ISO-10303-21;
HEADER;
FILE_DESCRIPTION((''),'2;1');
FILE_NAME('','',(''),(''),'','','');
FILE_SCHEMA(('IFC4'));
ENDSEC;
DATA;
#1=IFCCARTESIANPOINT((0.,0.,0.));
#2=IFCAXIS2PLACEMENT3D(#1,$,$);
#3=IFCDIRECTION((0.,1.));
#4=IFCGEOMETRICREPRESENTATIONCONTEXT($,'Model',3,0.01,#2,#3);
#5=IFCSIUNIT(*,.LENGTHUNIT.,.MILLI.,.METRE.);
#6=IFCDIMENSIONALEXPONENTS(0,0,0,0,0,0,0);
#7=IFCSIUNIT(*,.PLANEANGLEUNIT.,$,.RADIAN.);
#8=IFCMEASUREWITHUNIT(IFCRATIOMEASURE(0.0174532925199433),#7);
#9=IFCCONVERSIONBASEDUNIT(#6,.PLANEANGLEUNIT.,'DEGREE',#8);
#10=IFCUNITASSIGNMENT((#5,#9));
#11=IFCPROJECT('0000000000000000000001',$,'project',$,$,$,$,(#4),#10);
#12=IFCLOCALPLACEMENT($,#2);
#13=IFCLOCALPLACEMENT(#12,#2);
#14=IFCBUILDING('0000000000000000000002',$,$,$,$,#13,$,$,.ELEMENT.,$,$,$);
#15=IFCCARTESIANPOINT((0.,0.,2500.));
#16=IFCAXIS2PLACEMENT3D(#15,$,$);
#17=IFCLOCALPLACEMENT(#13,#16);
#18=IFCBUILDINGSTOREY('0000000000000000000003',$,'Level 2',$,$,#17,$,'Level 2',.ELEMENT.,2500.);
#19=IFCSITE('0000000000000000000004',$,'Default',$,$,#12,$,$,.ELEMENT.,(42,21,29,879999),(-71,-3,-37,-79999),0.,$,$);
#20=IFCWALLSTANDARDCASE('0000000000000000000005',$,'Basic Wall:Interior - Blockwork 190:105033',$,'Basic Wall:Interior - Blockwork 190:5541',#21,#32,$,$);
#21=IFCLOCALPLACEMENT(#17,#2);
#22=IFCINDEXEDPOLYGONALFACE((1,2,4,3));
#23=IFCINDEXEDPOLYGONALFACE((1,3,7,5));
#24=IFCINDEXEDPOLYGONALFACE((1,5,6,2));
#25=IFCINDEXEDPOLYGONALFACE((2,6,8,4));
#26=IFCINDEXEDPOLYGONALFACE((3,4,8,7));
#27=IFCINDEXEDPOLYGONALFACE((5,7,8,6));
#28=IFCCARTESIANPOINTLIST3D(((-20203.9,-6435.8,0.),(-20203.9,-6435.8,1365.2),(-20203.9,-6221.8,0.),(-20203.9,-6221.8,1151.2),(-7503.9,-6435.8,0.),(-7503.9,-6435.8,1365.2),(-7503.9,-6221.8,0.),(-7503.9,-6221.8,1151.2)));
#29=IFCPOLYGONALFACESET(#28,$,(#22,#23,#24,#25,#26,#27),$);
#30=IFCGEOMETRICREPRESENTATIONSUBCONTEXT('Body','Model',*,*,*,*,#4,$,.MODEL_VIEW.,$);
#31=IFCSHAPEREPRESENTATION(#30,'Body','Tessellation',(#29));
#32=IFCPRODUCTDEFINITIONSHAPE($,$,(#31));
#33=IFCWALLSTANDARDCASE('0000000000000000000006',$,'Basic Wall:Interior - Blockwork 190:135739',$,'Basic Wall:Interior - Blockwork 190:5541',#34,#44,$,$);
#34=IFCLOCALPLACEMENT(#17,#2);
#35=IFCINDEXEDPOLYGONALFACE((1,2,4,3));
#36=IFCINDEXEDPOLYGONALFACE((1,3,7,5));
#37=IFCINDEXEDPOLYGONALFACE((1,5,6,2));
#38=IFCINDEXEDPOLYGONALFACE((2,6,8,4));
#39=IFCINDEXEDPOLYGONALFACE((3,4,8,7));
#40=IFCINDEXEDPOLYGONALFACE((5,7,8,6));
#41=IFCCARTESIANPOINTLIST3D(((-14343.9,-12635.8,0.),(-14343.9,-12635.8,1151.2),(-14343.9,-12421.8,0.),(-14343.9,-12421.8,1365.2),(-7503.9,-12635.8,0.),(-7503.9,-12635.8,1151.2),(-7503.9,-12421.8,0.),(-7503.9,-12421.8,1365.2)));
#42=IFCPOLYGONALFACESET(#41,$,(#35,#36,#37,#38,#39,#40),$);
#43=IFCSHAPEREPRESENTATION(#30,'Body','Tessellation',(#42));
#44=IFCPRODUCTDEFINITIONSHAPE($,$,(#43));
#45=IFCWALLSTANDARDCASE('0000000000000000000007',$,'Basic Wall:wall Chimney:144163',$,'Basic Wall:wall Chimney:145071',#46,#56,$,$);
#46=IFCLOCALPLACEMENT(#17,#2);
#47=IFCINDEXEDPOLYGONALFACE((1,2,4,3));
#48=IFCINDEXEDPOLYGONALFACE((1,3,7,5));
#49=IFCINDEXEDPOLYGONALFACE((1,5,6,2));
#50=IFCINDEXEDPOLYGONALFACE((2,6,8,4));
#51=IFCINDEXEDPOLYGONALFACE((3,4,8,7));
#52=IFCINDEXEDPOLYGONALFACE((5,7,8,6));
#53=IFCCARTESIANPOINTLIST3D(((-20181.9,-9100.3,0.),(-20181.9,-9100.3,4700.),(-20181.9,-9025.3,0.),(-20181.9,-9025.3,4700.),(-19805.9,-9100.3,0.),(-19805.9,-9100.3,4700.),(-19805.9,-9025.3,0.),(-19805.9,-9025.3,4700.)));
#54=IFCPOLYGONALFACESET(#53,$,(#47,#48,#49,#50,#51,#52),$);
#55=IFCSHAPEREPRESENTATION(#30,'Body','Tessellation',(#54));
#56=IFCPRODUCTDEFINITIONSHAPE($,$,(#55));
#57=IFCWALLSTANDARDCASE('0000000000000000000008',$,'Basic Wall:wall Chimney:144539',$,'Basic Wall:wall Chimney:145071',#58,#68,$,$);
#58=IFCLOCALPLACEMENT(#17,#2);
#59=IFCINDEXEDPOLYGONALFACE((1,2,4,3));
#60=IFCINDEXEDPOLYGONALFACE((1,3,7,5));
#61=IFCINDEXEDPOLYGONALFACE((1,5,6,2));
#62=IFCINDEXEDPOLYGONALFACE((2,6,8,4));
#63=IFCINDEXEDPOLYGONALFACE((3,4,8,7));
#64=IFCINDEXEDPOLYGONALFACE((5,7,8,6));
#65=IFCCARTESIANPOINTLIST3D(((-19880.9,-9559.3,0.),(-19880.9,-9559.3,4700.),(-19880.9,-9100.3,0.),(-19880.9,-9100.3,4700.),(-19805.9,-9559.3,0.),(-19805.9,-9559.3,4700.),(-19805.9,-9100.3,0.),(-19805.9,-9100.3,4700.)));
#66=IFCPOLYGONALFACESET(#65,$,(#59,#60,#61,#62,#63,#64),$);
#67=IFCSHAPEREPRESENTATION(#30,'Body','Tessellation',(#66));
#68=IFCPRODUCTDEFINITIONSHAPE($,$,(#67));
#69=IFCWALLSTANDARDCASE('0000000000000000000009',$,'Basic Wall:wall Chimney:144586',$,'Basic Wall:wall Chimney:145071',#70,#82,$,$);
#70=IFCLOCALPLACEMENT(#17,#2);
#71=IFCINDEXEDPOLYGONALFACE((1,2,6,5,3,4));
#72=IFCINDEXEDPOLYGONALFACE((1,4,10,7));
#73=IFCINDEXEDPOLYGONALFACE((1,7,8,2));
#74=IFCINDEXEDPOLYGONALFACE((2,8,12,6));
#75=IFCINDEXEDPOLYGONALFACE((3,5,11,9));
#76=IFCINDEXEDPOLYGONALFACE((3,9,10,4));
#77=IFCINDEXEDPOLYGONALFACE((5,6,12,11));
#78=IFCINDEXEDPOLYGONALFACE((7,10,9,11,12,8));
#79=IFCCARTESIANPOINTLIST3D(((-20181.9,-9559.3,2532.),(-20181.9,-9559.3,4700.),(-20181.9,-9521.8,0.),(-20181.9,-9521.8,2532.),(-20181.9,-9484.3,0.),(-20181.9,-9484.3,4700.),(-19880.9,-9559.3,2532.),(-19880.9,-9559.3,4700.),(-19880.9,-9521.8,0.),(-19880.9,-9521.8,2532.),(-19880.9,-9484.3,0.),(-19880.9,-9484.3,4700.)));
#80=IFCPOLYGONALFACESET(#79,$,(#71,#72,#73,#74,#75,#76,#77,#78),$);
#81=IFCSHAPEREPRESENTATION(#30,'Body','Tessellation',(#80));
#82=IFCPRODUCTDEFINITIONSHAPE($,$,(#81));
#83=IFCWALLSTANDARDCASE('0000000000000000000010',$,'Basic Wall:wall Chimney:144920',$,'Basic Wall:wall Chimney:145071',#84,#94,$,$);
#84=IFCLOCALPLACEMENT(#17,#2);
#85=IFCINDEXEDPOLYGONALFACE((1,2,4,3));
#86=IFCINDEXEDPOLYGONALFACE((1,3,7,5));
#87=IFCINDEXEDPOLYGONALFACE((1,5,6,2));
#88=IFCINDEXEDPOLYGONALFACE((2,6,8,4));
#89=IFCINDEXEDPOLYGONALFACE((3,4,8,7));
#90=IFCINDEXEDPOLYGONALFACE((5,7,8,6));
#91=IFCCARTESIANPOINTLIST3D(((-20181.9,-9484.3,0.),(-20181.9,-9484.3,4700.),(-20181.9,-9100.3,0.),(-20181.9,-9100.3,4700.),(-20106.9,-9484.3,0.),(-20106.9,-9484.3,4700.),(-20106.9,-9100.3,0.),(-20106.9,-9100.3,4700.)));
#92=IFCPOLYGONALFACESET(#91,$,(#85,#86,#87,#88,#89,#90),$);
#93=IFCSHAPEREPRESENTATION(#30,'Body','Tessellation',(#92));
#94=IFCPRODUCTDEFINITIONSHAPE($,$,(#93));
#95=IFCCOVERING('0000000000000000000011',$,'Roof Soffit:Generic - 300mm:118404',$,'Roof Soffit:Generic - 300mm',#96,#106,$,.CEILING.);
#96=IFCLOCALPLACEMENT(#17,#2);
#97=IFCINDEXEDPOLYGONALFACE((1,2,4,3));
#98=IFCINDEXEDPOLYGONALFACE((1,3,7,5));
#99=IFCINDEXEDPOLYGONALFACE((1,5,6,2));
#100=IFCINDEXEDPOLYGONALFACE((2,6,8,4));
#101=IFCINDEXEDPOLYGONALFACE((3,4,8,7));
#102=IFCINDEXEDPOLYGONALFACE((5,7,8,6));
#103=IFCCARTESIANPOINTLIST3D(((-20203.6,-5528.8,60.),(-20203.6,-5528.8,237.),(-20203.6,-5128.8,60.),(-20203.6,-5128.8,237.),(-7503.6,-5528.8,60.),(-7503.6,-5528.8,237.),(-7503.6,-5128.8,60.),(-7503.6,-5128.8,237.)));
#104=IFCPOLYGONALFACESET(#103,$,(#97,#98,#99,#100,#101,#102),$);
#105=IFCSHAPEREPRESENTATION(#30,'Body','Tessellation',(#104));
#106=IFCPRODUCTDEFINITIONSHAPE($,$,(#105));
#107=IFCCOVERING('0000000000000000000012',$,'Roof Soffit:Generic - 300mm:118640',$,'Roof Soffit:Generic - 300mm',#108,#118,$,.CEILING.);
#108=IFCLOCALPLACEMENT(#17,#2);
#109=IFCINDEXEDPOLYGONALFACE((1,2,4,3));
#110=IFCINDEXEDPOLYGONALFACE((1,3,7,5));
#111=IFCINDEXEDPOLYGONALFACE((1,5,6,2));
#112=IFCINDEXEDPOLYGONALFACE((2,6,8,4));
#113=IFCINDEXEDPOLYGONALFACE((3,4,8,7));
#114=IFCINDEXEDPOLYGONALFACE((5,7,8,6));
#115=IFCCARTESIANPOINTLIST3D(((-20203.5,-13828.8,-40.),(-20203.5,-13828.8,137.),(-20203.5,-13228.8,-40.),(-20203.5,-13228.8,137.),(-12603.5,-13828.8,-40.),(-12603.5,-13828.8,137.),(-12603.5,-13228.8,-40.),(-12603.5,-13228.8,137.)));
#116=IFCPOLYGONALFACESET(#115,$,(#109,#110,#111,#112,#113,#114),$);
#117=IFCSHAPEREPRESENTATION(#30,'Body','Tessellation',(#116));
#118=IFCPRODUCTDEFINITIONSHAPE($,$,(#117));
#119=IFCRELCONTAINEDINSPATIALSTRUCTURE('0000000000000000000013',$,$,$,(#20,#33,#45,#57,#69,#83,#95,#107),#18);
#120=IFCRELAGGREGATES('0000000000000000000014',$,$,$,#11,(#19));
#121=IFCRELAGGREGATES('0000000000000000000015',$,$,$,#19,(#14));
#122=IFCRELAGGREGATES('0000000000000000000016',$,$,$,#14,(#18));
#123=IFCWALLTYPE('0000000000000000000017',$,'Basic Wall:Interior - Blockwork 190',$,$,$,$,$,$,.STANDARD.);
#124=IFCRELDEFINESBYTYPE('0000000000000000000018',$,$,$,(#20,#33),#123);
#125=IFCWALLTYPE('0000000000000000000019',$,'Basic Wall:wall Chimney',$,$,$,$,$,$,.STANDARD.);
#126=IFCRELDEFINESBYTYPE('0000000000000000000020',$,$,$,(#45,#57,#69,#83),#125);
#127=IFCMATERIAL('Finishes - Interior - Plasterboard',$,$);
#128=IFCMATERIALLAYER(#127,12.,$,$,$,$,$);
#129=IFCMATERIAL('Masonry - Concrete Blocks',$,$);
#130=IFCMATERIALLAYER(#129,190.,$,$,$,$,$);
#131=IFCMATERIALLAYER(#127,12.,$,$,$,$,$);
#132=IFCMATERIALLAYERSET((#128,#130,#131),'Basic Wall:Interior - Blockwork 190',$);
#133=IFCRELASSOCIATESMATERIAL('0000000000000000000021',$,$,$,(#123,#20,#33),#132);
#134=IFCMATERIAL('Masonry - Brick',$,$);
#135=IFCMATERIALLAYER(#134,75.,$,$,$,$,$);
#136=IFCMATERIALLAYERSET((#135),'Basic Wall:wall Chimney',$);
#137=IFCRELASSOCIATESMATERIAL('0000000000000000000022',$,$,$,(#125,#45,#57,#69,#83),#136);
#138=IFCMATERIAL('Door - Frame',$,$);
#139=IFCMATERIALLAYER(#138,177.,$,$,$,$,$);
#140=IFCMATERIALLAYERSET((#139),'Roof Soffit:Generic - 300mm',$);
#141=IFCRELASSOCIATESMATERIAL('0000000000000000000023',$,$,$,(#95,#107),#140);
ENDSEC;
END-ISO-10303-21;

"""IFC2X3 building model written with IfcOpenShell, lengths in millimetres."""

from ifc_helpers import new_model, entity, si_unit, converted_unit, direction, frame, frame_2d, origin, place, context, subcontext, project, spatial, polyline, rectangle, extrude, clip, bounded_halfspace, material, layer, layer_set, layer_usage, type_object, element, save


model = new_model("IFC2X3")

# Units and contexts
model_context = context("Model", 3, precision=0.01, world=origin(), true_north=direction((0.0, 1.0)))
body_context = subcontext(model_context, "Body", "Model", "MODEL_VIEW")
ifc_project = project(units=[si_unit("LENGTHUNIT", "METRE", prefix="MILLI"), converted_unit("PLANEANGLEUNIT", "DEGREE", entity("IfcRatioMeasure", 0.0174532925199433), si_unit("PLANEANGLEUNIT", "RADIAN"), dimensions=[0, 0, 0, 0, 0, 0, 0])], contexts=[model_context])

# Site, building, storey
site_placement = place(None, origin())
site = spatial("IfcSite", under=ifc_project, at=site_placement, Name="Default", CompositionType="ELEMENT", RefLatitude=(42, 21, 29, 879999), RefLongitude=(-71, -3, -37, -79999), RefElevation=0.0)
building_placement = place(site_placement, origin())
building = spatial("IfcBuilding", under=site, at=building_placement, CompositionType="ELEMENT")
storey_placement = place(building_placement, frame((0.0, 0.0, 2500.0)))
storey = spatial("IfcBuildingStorey", under=building, at=storey_placement, Name="Level 2", LongName="Level 2", CompositionType="ELEMENT", Elevation=2500.0)

# Shared definitions
ifc_material_1 = material(Name="Masonry - Brick")
ifc_material_2 = material(Name="Finishes - Interior - Plasterboard")

# Shared definitions
ifc_material_3 = material(Name="Door - Frame")

# Walls
ifc_layer_1 = layer(ifc_material_2, 12.0)
ifc_material_4 = material(Name="Masonry - Concrete Blocks")
ifc_layer_2 = layer(ifc_material_4, 190.0)
ifc_layer_3 = layer(ifc_material_2, 12.0)
ifc_layer_set_1 = layer_set([ifc_layer_1, ifc_layer_2, ifc_layer_3], Name="Basic Wall:Interior - Blockwork 190")
wall_type_1 = type_object("IfcWallType", Name="Basic Wall:Interior - Blockwork 190", PredefinedType="STANDARD", material=ifc_layer_set_1)
ifc_layer_usage_1 = layer_usage(ifc_layer_set_1, "AXIS2", "NEGATIVE", 107.0)
wall_1_placement = place(storey_placement, frame((-20203.9, -6328.8, 0.0)))
element("IfcWallStandardCase", 1, at=wall_1_placement, inside=storey, type_object=wall_type_1, material=ifc_layer_usage_1, Name="Basic Wall:Interior - Blockwork 190:105033", ObjectType="Basic Wall:Interior - Blockwork 190:5541", context=body_context, shape_type="Clipping", body=[
    clip(extrude(rectangle(XDim=12700.0, YDim=214.0, at=frame_2d((6350.0, 0.0), x_axis=(-1.0, 0.0))), origin(), (0.0, 0.0, 1.0), 1365.2), bounded_halfspace(frame((0.0, -107.0, 1365.2), z_axis=(0.0, -0.707107, -0.707107), x_axis=(-1.0, 0.0, 0.0)), True, frame((0.0, -107.0, 1365.2)), polyline([(0.0, 0.0), (12700.0, 0.0), (12700.0, 214.0), (0.0, 214.0), (0.0, 0.0)]))),
])
ifc_layer_usage_2 = layer_usage(ifc_layer_set_1, "AXIS2", "NEGATIVE", 107.0)
wall_2_placement = place(storey_placement, frame((-14343.9, -12528.8, 0.0)))
element("IfcWallStandardCase", 2, at=wall_2_placement, inside=storey, type_object=wall_type_1, material=ifc_layer_usage_2, Name="Basic Wall:Interior - Blockwork 190:135739", ObjectType="Basic Wall:Interior - Blockwork 190:5541", context=body_context, shape_type="Clipping", body=[
    clip(extrude(rectangle(XDim=6840.0, YDim=214.0, at=frame_2d((3420.0, 0.0), x_axis=(-1.0, 0.0))), origin(), (0.0, 0.0, 1.0), 1365.2), bounded_halfspace(frame((0.0, -107.0, 1151.2), z_axis=(0.0, 0.707107, -0.707107), x_axis=(-1.0, 0.0, 0.0)), True, frame((0.0, -107.0, 1151.2)), polyline([(0.0, 0.0), (6840.0, 0.0), (6840.0, 214.0), (0.0, 214.0), (0.0, 0.0)]))),
])
ifc_layer_4 = layer(ifc_material_1, 75.0)
ifc_layer_set_2 = layer_set([ifc_layer_4], Name="Basic Wall:wall Chimney")
ifc_layer_usage_3 = layer_usage(ifc_layer_set_2, "AXIS2", "NEGATIVE", 37.5)
wall_type_2 = type_object("IfcWallType", Name="Basic Wall:wall Chimney", PredefinedType="STANDARD", material=ifc_layer_set_2)
wall_3_placement = place(storey_placement, frame((-20181.9, -9062.8, 0.0)))
element("IfcWallStandardCase", 3, at=wall_3_placement, inside=storey, type_object=wall_type_2, material=ifc_layer_usage_3, Name="Basic Wall:wall Chimney:144163", ObjectType="Basic Wall:wall Chimney:145071", context=body_context, shape_type="SweptSolid", body=[
    extrude(rectangle(XDim=376.0, YDim=75.0, at=frame_2d((188.0, 0.0), x_axis=(-1.0, 0.0))), origin(), (0.0, 0.0, 1.0), 4700.0),
])
ifc_layer_usage_4 = layer_usage(ifc_layer_set_2, "AXIS2", "NEGATIVE", 37.5)
wall_4_placement = place(storey_placement, frame((-19843.4, -9100.3, 0.0), z_axis=(0.0, 0.0, 1.0), x_axis=(0.0, -1.0, 0.0)))
element("IfcWallStandardCase", 4, at=wall_4_placement, inside=storey, type_object=wall_type_2, material=ifc_layer_usage_4, Name="Basic Wall:wall Chimney:144539", ObjectType="Basic Wall:wall Chimney:145071", context=body_context, shape_type="SweptSolid", body=[
    extrude(rectangle(XDim=459.0, YDim=75.0, at=frame_2d((229.5, 0.0), x_axis=(-1.0, 0.0))), origin(), (0.0, 0.0, 1.0), 4700.0),
])
ifc_layer_usage_5 = layer_usage(ifc_layer_set_2, "AXIS2", "NEGATIVE", 37.5)
wall_5_placement = place(storey_placement, frame((-19880.9, -9521.8, 0.0), z_axis=(0.0, 0.0, 1.0), x_axis=(-1.0, 0.0, 0.0)))
element("IfcWallStandardCase", 5, at=wall_5_placement, inside=storey, type_object=wall_type_2, material=ifc_layer_usage_5, Name="Basic Wall:wall Chimney:144586", ObjectType="Basic Wall:wall Chimney:145071", context=body_context, shape_type="Clipping", body=[
    clip(extrude(rectangle(XDim=301.0, YDim=75.0, at=frame_2d((150.5, 0.0), x_axis=(-1.0, 0.0))), origin(), (0.0, 0.0, 1.0), 4700.0), bounded_halfspace(frame((0.0, 0.0, 2532.0), z_axis=(0.0, 0.0, 1.0), x_axis=(0.0, 1.0, 0.0)), True, frame((0.0, 0.0, 2532.0)), polyline([(0.0, 0.0), (301.0, 0.0), (301.0, 37.5), (0.0, 37.5), (0.0, 0.0)]))),
])
ifc_layer_usage_6 = layer_usage(ifc_layer_set_2, "AXIS2", "NEGATIVE", 37.5)
wall_6_placement = place(storey_placement, frame((-20144.4, -9100.3, 0.0), z_axis=(0.0, 0.0, 1.0), x_axis=(0.0, -1.0, 0.0)))
element("IfcWallStandardCase", 6, at=wall_6_placement, inside=storey, type_object=wall_type_2, material=ifc_layer_usage_6, Name="Basic Wall:wall Chimney:144920", ObjectType="Basic Wall:wall Chimney:145071", context=body_context, shape_type="SweptSolid", body=[
    extrude(rectangle(XDim=384.0, YDim=75.0, at=frame_2d((192.0, 0.0), x_axis=(-1.0, 0.0))), origin(), (0.0, 0.0, 1.0), 4700.0),
])

# Coverings
ifc_layer_5 = layer(ifc_material_3, 177.0)
ifc_layer_set_3 = layer_set([ifc_layer_5], Name="Roof Soffit:Generic - 300mm")
ifc_layer_usage_7 = layer_usage(ifc_layer_set_3, "AXIS3", "NEGATIVE", 0.0)
covering_1_placement = place(storey_placement, origin())
element("IfcCovering", 7, at=covering_1_placement, inside=storey, material=ifc_layer_usage_7, Name="Roof Soffit:Generic - 300mm:118404", ObjectType="Roof Soffit:Generic - 300mm", PredefinedType="CEILING", context=body_context, shape_type="SweptSolid", body=[
    extrude(rectangle(XDim=12700.0, YDim=400.0, at=frame_2d((0.0, 0.0), x_axis=(1.0, 0.0))), frame((-13853.6, -5328.8, 60.0)), (0.0, 0.0, 1.0), 177.0),
])
ifc_layer_usage_8 = layer_usage(ifc_layer_set_3, "AXIS3", "NEGATIVE", 0.0)
covering_2_placement = place(storey_placement, origin())
element("IfcCovering", 8, at=covering_2_placement, inside=storey, material=ifc_layer_usage_8, Name="Roof Soffit:Generic - 300mm:118640", ObjectType="Roof Soffit:Generic - 300mm", PredefinedType="CEILING", context=body_context, shape_type="SweptSolid", body=[
    extrude(rectangle(XDim=7600.0, YDim=600.0, at=frame_2d((0.0, 0.0), x_axis=(1.0, 0.0))), frame((-16403.5, -13528.8, -40.0)), (0.0, 0.0, 1.0), 177.0),
])

save(model, "model.ifc")
